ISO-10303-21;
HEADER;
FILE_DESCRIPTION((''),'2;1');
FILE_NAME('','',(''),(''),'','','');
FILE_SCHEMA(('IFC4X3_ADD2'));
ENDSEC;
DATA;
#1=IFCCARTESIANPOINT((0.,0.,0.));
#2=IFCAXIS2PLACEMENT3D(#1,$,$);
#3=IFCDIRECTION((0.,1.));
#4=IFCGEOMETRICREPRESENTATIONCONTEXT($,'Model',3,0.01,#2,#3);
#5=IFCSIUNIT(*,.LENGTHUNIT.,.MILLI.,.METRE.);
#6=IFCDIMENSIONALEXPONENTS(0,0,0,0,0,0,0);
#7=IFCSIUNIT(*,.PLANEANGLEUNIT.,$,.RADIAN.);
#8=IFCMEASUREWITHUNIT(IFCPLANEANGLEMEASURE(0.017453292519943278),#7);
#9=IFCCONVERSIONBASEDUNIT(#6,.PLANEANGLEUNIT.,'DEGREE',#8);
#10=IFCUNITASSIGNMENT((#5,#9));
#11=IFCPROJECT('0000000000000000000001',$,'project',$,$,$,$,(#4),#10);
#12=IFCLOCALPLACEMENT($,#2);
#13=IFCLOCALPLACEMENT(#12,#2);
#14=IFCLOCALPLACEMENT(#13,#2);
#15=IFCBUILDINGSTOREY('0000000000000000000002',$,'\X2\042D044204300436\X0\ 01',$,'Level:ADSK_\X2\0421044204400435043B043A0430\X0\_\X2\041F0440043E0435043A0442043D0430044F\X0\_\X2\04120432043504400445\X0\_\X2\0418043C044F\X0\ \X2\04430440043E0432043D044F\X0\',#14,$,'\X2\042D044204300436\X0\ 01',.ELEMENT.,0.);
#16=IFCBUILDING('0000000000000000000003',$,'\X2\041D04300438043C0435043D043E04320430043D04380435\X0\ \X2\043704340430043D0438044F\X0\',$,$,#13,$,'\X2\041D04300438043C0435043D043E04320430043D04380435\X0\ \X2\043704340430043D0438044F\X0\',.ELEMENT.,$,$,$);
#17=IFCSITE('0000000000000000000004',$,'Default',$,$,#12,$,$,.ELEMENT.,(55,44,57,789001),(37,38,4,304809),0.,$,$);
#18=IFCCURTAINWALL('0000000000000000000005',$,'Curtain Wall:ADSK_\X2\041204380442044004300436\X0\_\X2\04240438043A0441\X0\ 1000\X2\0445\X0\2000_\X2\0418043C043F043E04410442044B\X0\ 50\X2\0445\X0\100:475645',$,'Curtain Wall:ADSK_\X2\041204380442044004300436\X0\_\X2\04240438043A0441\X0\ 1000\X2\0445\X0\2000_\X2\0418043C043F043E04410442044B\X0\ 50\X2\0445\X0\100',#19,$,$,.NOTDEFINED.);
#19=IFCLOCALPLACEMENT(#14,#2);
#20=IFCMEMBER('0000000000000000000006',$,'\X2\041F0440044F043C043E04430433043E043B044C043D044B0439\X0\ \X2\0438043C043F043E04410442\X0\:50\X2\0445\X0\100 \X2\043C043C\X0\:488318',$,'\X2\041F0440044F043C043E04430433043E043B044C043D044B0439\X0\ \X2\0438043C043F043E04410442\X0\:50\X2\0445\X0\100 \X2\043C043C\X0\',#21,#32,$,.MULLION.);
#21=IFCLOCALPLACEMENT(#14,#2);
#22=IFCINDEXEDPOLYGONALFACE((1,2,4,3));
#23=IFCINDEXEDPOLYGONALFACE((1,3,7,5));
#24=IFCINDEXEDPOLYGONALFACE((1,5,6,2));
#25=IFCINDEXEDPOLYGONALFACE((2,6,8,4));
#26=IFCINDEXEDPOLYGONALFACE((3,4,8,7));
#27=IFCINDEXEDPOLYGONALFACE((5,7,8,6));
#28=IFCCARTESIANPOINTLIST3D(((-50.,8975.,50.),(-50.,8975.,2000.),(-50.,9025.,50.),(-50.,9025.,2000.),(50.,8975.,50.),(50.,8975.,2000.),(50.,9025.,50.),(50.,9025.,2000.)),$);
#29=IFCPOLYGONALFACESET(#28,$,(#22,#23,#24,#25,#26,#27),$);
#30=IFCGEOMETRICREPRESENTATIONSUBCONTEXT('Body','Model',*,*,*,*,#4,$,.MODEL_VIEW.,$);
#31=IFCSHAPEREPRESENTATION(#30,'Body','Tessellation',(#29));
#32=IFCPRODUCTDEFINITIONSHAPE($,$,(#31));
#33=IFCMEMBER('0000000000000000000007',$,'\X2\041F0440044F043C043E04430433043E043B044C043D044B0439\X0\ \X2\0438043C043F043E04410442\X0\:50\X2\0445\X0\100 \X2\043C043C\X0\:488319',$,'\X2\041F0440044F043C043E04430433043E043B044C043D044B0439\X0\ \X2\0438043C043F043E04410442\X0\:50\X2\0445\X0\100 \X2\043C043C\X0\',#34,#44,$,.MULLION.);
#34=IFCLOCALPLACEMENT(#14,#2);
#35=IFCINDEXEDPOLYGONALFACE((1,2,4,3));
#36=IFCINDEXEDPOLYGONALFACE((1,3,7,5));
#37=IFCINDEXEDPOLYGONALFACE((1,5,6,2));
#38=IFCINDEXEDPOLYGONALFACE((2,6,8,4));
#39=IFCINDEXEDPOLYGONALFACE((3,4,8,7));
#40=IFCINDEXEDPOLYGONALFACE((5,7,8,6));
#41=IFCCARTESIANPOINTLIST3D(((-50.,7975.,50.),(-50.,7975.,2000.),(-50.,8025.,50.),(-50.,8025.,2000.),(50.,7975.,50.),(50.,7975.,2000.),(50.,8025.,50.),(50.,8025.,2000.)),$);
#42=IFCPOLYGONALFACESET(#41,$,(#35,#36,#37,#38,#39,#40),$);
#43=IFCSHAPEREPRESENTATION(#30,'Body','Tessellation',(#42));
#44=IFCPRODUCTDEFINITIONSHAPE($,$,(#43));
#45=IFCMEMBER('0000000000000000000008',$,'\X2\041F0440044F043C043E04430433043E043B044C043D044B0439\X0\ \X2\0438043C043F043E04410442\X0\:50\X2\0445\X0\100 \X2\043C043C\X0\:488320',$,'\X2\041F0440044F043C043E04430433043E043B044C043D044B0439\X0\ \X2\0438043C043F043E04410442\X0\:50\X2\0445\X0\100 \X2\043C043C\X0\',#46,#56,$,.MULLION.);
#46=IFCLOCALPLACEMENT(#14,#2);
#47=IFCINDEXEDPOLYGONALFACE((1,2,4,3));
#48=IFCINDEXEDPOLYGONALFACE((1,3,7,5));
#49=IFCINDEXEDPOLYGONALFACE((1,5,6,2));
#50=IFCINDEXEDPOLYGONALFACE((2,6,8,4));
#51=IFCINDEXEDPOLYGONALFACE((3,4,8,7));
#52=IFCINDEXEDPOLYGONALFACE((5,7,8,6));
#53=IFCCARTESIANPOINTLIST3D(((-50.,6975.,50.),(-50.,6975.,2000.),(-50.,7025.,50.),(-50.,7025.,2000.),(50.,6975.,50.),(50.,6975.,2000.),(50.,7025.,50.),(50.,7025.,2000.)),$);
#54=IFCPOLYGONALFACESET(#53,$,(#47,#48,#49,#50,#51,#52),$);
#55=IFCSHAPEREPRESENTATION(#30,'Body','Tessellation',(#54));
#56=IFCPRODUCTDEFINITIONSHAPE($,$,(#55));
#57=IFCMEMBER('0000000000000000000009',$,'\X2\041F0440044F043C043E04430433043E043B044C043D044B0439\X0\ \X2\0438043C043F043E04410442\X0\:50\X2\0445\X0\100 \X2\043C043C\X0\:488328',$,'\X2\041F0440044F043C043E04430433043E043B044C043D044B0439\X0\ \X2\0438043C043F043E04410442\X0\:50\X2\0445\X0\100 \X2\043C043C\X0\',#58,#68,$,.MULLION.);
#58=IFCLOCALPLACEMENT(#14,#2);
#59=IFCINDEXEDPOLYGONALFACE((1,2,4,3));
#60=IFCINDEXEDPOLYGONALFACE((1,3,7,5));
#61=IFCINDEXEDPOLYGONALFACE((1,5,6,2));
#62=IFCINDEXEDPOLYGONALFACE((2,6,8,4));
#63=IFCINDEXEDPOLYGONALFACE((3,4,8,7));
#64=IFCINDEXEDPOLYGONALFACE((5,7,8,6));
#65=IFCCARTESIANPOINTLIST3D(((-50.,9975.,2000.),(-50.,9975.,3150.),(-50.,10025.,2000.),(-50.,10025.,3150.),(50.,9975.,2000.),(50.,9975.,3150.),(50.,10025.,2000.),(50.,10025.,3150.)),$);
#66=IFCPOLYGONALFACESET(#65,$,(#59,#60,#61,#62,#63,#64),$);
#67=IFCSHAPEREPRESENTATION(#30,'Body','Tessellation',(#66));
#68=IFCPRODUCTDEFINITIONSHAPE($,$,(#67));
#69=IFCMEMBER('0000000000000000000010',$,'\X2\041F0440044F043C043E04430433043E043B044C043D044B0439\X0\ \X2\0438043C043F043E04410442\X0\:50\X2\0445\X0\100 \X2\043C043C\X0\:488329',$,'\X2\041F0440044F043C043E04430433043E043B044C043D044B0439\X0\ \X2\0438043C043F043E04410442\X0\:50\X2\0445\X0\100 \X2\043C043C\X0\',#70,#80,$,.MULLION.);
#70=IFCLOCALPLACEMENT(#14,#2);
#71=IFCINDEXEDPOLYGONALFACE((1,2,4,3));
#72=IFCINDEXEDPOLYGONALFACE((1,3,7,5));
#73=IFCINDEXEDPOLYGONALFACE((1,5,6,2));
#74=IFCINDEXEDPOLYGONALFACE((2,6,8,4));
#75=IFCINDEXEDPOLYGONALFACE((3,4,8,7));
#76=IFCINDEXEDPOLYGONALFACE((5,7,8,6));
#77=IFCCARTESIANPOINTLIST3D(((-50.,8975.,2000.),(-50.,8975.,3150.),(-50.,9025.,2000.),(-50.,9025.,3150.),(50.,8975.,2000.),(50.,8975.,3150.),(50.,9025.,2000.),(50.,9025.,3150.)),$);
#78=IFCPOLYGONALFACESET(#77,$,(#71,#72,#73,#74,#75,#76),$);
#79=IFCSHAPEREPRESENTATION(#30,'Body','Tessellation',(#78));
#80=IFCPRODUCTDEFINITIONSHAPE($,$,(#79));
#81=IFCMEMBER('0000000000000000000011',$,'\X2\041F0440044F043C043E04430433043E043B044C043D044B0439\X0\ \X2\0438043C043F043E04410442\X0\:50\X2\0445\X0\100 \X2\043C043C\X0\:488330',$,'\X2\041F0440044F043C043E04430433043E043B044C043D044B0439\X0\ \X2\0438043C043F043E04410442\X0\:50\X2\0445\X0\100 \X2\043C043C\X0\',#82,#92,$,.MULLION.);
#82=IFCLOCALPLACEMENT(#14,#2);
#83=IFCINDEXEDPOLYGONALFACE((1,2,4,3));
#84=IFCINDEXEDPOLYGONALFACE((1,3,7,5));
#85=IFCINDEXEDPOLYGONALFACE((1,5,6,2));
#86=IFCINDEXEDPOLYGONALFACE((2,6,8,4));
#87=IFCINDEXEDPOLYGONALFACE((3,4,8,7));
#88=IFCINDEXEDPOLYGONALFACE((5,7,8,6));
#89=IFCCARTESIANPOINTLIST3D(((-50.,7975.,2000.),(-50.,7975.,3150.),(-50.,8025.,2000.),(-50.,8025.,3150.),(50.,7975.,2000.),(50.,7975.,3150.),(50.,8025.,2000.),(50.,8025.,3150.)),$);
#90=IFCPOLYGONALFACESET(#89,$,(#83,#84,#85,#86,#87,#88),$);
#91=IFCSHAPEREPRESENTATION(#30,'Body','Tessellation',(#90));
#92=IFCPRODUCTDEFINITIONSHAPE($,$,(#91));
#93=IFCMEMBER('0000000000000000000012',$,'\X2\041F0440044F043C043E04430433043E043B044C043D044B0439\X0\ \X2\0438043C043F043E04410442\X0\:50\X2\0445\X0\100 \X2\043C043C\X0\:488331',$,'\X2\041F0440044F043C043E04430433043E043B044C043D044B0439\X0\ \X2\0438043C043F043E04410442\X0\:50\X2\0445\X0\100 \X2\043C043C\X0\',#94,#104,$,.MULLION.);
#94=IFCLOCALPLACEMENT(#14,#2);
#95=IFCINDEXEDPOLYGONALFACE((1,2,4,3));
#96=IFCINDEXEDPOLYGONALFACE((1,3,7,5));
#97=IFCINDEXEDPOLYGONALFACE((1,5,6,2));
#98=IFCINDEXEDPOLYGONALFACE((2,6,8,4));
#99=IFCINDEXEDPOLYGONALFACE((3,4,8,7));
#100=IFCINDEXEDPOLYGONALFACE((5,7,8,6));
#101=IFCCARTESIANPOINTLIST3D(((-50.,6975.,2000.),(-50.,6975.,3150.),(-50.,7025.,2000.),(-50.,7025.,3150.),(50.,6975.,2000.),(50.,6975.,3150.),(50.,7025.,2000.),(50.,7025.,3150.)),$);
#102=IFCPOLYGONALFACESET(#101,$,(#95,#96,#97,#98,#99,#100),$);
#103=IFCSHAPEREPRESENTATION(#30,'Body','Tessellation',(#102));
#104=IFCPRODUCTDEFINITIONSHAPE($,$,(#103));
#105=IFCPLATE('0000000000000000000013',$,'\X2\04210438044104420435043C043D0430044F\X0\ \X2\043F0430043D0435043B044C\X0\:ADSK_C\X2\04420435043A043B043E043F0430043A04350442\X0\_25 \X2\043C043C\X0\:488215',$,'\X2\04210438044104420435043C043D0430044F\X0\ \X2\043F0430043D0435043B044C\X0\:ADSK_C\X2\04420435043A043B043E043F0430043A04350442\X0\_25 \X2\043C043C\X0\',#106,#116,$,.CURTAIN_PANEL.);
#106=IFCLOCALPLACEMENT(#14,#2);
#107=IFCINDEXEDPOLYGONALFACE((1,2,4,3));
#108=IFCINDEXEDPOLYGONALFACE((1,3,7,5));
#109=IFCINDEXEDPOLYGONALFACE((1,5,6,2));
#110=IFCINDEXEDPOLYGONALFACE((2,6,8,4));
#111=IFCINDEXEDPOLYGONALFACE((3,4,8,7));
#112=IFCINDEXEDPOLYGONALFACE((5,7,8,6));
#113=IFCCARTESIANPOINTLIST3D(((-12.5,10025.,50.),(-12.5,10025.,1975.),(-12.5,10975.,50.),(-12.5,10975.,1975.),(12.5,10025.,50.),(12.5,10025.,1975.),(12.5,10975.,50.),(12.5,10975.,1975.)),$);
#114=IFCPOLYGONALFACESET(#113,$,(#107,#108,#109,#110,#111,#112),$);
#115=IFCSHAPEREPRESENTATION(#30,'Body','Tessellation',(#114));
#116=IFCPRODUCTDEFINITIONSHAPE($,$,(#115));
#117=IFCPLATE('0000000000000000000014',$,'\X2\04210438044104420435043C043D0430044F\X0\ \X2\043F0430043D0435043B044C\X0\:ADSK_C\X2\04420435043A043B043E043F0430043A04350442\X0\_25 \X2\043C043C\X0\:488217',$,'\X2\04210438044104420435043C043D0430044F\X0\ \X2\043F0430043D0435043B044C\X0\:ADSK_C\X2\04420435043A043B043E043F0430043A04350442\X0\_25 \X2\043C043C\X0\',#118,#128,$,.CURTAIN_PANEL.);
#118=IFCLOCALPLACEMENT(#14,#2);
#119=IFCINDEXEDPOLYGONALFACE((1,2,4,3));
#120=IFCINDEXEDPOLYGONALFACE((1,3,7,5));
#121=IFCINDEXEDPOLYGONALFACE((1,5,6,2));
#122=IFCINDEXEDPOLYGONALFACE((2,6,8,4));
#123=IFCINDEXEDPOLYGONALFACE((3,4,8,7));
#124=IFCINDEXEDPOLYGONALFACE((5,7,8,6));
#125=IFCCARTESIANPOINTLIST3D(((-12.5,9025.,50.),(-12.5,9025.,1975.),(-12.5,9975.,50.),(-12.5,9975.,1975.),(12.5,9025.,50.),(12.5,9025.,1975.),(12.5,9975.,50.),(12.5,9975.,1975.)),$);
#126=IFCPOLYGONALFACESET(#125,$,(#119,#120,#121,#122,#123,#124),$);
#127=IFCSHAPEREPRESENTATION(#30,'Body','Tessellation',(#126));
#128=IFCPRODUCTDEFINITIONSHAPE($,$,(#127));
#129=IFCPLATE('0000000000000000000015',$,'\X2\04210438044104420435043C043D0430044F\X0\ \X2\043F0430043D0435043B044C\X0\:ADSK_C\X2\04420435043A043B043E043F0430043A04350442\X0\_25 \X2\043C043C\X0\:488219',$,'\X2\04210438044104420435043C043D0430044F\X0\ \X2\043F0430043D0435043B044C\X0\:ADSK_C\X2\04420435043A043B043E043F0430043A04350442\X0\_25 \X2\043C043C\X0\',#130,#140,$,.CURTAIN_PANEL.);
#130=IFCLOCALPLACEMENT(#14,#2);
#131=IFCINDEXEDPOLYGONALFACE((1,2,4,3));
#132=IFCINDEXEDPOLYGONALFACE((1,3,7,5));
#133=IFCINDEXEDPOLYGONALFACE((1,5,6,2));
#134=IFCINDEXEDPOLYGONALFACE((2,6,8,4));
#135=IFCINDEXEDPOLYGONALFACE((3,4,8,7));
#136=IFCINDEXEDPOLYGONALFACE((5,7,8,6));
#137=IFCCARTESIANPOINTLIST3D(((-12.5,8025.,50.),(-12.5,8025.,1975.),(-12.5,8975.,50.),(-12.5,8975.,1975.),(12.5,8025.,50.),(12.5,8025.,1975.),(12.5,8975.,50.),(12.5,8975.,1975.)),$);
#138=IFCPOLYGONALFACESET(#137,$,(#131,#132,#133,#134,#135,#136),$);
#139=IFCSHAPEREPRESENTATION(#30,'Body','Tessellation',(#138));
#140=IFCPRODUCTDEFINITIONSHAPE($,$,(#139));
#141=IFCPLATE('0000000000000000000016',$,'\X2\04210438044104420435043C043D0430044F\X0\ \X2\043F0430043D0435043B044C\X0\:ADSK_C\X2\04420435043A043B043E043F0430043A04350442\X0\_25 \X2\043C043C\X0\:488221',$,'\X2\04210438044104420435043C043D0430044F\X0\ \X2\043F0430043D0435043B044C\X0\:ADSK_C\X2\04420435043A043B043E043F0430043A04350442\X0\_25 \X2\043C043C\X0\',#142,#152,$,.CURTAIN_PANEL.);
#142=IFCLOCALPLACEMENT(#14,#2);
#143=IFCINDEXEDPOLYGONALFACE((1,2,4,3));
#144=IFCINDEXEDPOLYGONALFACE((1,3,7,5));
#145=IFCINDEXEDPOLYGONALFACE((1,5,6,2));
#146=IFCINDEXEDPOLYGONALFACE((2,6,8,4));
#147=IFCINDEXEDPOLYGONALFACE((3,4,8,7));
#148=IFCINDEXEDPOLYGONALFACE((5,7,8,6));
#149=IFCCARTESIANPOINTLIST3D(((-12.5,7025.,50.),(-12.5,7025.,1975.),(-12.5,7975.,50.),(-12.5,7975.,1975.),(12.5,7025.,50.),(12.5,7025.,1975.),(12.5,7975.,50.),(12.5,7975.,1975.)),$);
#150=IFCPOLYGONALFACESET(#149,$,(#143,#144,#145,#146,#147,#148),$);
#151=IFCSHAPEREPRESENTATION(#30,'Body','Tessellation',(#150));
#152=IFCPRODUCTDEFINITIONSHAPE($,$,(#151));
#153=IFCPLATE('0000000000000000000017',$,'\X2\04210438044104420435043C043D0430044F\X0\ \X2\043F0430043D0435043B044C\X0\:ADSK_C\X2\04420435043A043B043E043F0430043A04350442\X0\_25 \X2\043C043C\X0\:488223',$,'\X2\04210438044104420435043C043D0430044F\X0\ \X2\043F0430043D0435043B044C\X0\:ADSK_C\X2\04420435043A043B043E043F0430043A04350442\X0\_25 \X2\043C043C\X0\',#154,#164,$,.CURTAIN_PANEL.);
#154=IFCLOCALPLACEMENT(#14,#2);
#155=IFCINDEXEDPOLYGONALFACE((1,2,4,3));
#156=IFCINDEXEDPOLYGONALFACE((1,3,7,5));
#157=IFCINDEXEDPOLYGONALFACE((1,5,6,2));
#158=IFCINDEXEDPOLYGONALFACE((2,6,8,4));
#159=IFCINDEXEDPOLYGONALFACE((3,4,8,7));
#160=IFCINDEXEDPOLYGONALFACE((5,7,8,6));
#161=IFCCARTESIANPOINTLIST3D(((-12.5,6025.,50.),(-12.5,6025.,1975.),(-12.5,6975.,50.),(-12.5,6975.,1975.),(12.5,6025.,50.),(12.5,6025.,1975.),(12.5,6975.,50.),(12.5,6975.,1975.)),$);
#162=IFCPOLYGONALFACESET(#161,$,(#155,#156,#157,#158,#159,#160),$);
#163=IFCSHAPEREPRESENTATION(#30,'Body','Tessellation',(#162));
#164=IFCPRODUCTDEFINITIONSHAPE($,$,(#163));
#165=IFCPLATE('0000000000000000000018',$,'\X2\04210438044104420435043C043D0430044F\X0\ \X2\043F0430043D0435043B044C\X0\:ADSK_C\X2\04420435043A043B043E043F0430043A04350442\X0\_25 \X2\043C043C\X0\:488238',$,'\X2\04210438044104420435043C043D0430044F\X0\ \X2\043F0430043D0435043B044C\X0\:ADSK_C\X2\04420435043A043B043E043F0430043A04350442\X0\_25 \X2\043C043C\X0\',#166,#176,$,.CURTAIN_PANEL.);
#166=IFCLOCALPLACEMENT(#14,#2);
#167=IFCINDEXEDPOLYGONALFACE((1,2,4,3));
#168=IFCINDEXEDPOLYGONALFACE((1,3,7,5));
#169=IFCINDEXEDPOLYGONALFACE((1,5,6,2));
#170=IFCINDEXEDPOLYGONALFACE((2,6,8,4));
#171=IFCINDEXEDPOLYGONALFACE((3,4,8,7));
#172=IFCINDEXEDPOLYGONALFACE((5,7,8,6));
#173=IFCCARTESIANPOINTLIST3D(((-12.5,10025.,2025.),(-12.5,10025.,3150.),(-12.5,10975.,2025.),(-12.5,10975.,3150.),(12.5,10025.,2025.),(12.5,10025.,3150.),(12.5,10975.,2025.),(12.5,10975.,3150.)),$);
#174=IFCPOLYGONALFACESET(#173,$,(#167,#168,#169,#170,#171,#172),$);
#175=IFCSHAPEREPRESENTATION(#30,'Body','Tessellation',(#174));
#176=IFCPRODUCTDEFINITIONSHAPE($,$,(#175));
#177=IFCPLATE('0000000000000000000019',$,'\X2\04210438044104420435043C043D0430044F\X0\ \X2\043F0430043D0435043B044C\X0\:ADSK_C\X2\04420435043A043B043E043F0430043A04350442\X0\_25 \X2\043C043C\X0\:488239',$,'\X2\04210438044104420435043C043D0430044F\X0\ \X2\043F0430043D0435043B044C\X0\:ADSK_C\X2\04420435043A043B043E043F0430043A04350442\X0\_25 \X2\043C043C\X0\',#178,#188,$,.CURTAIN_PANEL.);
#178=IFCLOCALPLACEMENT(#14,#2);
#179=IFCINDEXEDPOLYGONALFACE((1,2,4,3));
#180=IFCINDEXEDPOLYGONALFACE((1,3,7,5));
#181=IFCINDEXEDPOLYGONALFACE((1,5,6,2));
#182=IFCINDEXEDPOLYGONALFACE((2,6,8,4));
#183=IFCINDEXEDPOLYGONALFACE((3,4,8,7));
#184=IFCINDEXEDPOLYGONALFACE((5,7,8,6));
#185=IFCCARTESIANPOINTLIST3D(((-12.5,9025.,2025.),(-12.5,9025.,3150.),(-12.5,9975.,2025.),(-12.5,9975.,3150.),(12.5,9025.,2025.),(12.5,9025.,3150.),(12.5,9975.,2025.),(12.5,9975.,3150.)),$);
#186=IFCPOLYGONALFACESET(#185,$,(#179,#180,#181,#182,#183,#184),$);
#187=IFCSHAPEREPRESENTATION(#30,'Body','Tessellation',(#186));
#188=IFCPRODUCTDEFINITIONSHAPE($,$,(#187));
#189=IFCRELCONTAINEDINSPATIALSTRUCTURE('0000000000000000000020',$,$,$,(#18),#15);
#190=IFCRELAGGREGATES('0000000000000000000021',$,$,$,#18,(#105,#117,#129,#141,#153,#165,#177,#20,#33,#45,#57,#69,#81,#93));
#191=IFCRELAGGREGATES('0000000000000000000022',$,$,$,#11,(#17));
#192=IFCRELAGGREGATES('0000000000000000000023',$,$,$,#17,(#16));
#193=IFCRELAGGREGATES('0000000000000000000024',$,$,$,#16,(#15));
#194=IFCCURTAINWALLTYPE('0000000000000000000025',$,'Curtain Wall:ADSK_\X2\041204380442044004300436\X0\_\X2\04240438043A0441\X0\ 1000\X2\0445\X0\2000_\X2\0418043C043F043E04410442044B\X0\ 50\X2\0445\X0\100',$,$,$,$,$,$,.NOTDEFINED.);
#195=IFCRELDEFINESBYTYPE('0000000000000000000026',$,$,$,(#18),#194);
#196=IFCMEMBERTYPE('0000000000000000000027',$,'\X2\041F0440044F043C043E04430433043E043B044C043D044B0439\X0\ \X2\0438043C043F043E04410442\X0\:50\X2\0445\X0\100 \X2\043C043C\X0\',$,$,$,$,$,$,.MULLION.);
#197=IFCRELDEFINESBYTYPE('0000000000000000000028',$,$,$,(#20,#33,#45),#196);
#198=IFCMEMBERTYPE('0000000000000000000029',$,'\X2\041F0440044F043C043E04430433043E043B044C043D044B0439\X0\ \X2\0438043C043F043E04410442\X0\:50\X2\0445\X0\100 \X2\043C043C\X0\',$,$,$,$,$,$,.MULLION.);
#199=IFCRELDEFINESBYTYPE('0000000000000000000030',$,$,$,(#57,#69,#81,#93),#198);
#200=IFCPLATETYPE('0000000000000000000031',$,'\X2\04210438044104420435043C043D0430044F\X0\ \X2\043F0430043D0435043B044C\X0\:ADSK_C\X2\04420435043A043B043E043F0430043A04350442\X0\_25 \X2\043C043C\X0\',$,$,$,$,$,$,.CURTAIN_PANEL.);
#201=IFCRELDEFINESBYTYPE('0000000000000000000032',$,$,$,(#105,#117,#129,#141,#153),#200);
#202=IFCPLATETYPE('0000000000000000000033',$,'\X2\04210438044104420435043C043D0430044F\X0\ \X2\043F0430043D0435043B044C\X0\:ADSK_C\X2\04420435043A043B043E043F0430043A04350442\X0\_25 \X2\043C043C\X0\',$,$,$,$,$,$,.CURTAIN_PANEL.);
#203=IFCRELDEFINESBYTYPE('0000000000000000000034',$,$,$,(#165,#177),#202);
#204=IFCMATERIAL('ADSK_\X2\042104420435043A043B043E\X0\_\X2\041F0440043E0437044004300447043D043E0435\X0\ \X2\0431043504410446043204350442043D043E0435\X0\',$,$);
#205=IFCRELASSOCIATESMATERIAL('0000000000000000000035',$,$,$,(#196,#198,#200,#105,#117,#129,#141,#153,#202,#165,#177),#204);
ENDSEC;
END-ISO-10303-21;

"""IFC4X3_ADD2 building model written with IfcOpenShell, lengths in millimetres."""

from ifc_helpers import new_model, entity, si_unit, converted_unit, direction, frame, frame_2d, origin, origin_2d_with_axis, place, context, subcontext, project, spatial, rectangle, extrude, source, transform, mapped, material, material_profile, profile_set, type_object, type_shapes, element, aggregate, save


model = new_model("IFC4X3_ADD2")

# Units and contexts
model_context = context("Model", 3, precision=0.01, world=origin(), true_north=direction((0.0, 1.0)))
body_context = subcontext(model_context, "Body", "Model", "MODEL_VIEW")
ifc_project = project(units=[si_unit("LENGTHUNIT", "METRE", prefix="MILLI"), converted_unit("PLANEANGLEUNIT", "DEGREE", entity("IfcPlaneAngleMeasure", 0.017453292519943278), si_unit("PLANEANGLEUNIT", "RADIAN"), dimensions=[0, 0, 0, 0, 0, 0, 0])], contexts=[model_context])

# Site, building, storey
site_placement = place(None, origin())
site = spatial("IfcSite", under=ifc_project, at=site_placement, Name="Default", CompositionType="ELEMENT", RefLatitude=(55, 44, 57, 789001), RefLongitude=(37, 38, 4, 304809), RefElevation=0.0)
building_placement = place(site_placement, origin())
building = spatial("IfcBuilding", under=site, at=building_placement, Name="Наименование здания", LongName="Наименование здания", CompositionType="ELEMENT")
storey_placement = place(building_placement, origin())
storey = spatial("IfcBuildingStorey", under=building, at=storey_placement, Name="Этаж 01", ObjectType="Level:ADSK_Стрелка_Проектная_Вверх_Имя уровня", LongName="Этаж 01", CompositionType="ELEMENT", Elevation=0.0)

# Curtain wall, members, plates
curtain_wall_type = type_object("IfcCurtainWallType", Name="Curtain Wall:ADSK_Витраж_Фикс 1000х2000_Импосты 50х100", PredefinedType="NOTDEFINED")
curtain_wall_placement = place(storey_placement, origin())
curtain_wall = element("IfcCurtainWall", 1, at=curtain_wall_placement, inside=storey, type_object=curtain_wall_type, Name="Curtain Wall:ADSK_Витраж_Фикс 1000х2000_Импосты 50х100:475645", ObjectType="Curtain Wall:ADSK_Витраж_Фикс 1000х2000_Импосты 50х100", PredefinedType="NOTDEFINED")
ifc_material = material(Name="ADSK_Стекло_Прозрачное бесцветное")
ifc_material_profile = material_profile(ifc_material, rectangle(XDim=50.0, YDim=100.0, at=frame_2d((0.0, 0.0), x_axis=(1.0, 0.0))), Name="50х100 мм")
ifc_profile_set = profile_set([ifc_material_profile], Name="50х100 мм")
member_type_1 = type_object("IfcMemberType", Name="Прямоугольный импост:50х100 мм", PredefinedType="MULLION", material=ifc_profile_set)
shared_shape_1 = source(origin(), body_context, "Body", "SweptSolid", [
    extrude(rectangle(XDim=50.0, YDim=100.0, at=frame_2d((0.0, 0.0), x_axis=(1.0, 0.0))), frame((0.0, 0.0, -1950.0), z_axis=(0.0, 0.0, 1.0), x_axis=(-1.0, 0.0, 0.0)), (0.0, 0.0, 1.0), 1950.0),
])
type_shapes(member_type_1, [shared_shape_1])
member_1_placement = place(curtain_wall_placement, frame((0.0, 9000.0, 50.0), z_axis=(0.0, 0.0, -1.0), x_axis=(0.0, -1.0, 0.0)))
member_1 = element("IfcMember", 2, at=member_1_placement, type_object=member_type_1, Name="Прямоугольный импост:50х100 мм:488318", ObjectType="Прямоугольный импост:50х100 мм", PredefinedType="MULLION", context=body_context, shape_type="MappedRepresentation", body=[
    mapped(shared_shape_1, transform((0.0, 0.0, 0.0), scale=1.0)),
])
member_2_placement = place(curtain_wall_placement, frame((0.0, 8000.0, 50.0), z_axis=(0.0, 0.0, -1.0), x_axis=(0.0, -1.0, 0.0)))
member_2 = element("IfcMember", 3, at=member_2_placement, type_object=member_type_1, Name="Прямоугольный импост:50х100 мм:488319", ObjectType="Прямоугольный импост:50х100 мм", PredefinedType="MULLION", context=body_context, shape_type="MappedRepresentation", body=[
    mapped(shared_shape_1, transform((0.0, 0.0, 0.0), scale=1.0)),
])
member_3_placement = place(curtain_wall_placement, frame((0.0, 7000.0, 50.0), z_axis=(0.0, 0.0, -1.0), x_axis=(0.0, -1.0, 0.0)))
member_3 = element("IfcMember", 4, at=member_3_placement, type_object=member_type_1, Name="Прямоугольный импост:50х100 мм:488320", ObjectType="Прямоугольный импост:50х100 мм", PredefinedType="MULLION", context=body_context, shape_type="MappedRepresentation", body=[
    mapped(shared_shape_1, transform((0.0, 0.0, 0.0), scale=1.0)),
])
member_type_2 = type_object("IfcMemberType", Name="Прямоугольный импост:50х100 мм", PredefinedType="MULLION", material=ifc_profile_set)
shared_shape_2 = source(origin(), body_context, "Body", "SweptSolid", [
    extrude(rectangle(XDim=50.0, YDim=100.0, at=frame_2d((0.0, 0.0), x_axis=(1.0, 0.0))), frame((0.0, 0.0, -1150.0), z_axis=(0.0, 0.0, 1.0), x_axis=(-1.0, 0.0, 0.0)), (0.0, 0.0, 1.0), 1150.0),
])
type_shapes(member_type_2, [shared_shape_2])
member_4_placement = place(curtain_wall_placement, frame((0.0, 10000.0, 2000.0), z_axis=(0.0, 0.0, -1.0), x_axis=(0.0, -1.0, 0.0)))
member_4 = element("IfcMember", 5, at=member_4_placement, type_object=member_type_2, Name="Прямоугольный импост:50х100 мм:488328", ObjectType="Прямоугольный импост:50х100 мм", PredefinedType="MULLION", context=body_context, shape_type="MappedRepresentation", body=[
    mapped(shared_shape_2, transform((0.0, 0.0, 0.0), scale=1.0)),
])
member_5_placement = place(curtain_wall_placement, frame((0.0, 9000.0, 2000.0), z_axis=(0.0, 0.0, -1.0), x_axis=(0.0, -1.0, 0.0)))
member_5 = element("IfcMember", 6, at=member_5_placement, type_object=member_type_2, Name="Прямоугольный импост:50х100 мм:488329", ObjectType="Прямоугольный импост:50х100 мм", PredefinedType="MULLION", context=body_context, shape_type="MappedRepresentation", body=[
    mapped(shared_shape_2, transform((0.0, 0.0, 0.0), scale=1.0)),
])
member_6_placement = place(curtain_wall_placement, frame((0.0, 8000.0, 2000.0), z_axis=(0.0, 0.0, -1.0), x_axis=(0.0, -1.0, 0.0)))
member_6 = element("IfcMember", 7, at=member_6_placement, type_object=member_type_2, Name="Прямоугольный импост:50х100 мм:488330", ObjectType="Прямоугольный импост:50х100 мм", PredefinedType="MULLION", context=body_context, shape_type="MappedRepresentation", body=[
    mapped(shared_shape_2, transform((0.0, 0.0, 0.0), scale=1.0)),
])
member_7_placement = place(curtain_wall_placement, frame((0.0, 7000.0, 2000.0), z_axis=(0.0, 0.0, -1.0), x_axis=(0.0, -1.0, 0.0)))
member_7 = element("IfcMember", 8, at=member_7_placement, type_object=member_type_2, Name="Прямоугольный импост:50х100 мм:488331", ObjectType="Прямоугольный импост:50х100 мм", PredefinedType="MULLION", context=body_context, shape_type="MappedRepresentation", body=[
    mapped(shared_shape_2, transform((0.0, 0.0, 0.0), scale=1.0)),
])
plate_type_1 = type_object("IfcPlateType", Name="Системная панель:ADSK_Cтеклопакет_25 мм", PredefinedType="CURTAIN_PANEL", material=ifc_material)
shared_shape_3 = source(origin(), body_context, "Body", "SweptSolid", [
    extrude(rectangle(XDim=25.0, YDim=950.0, at=origin_2d_with_axis()), frame((0.0, 0.0, 0.0), z_axis=(0.0, 0.0, 1.0), x_axis=(0.0, 1.0, 0.0)), (0.0, 0.0, 1.0), 1925.0),
])
type_shapes(plate_type_1, [shared_shape_3])
plate_1_placement = place(curtain_wall_placement, frame((0.0, 10500.0, 50.0), z_axis=(0.0, 0.0, 1.0), x_axis=(0.0, -1.0, 0.0)))
plate_1 = element("IfcPlate", 9, at=plate_1_placement, type_object=plate_type_1, material=ifc_material, Name="Системная панель:ADSK_Cтеклопакет_25 мм:488215", ObjectType="Системная панель:ADSK_Cтеклопакет_25 мм", PredefinedType="CURTAIN_PANEL", context=body_context, shape_type="MappedRepresentation", body=[
    mapped(shared_shape_3, transform((0.0, 0.0, 0.0), scale=1.0)),
])
plate_2_placement = place(curtain_wall_placement, frame((0.0, 9500.0, 50.0), z_axis=(0.0, 0.0, 1.0), x_axis=(0.0, -1.0, 0.0)))
plate_2 = element("IfcPlate", 10, at=plate_2_placement, type_object=plate_type_1, material=ifc_material, Name="Системная панель:ADSK_Cтеклопакет_25 мм:488217", ObjectType="Системная панель:ADSK_Cтеклопакет_25 мм", PredefinedType="CURTAIN_PANEL", context=body_context, shape_type="MappedRepresentation", body=[
    mapped(shared_shape_3, transform((0.0, 0.0, 0.0), scale=1.0)),
])
plate_3_placement = place(curtain_wall_placement, frame((0.0, 8500.0, 50.0), z_axis=(0.0, 0.0, 1.0), x_axis=(0.0, -1.0, 0.0)))
plate_3 = element("IfcPlate", 11, at=plate_3_placement, type_object=plate_type_1, material=ifc_material, Name="Системная панель:ADSK_Cтеклопакет_25 мм:488219", ObjectType="Системная панель:ADSK_Cтеклопакет_25 мм", PredefinedType="CURTAIN_PANEL", context=body_context, shape_type="MappedRepresentation", body=[
    mapped(shared_shape_3, transform((0.0, 0.0, 0.0), scale=1.0)),
])
plate_4_placement = place(curtain_wall_placement, frame((0.0, 7500.0, 50.0), z_axis=(0.0, 0.0, 1.0), x_axis=(0.0, -1.0, 0.0)))
plate_4 = element("IfcPlate", 12, at=plate_4_placement, type_object=plate_type_1, material=ifc_material, Name="Системная панель:ADSK_Cтеклопакет_25 мм:488221", ObjectType="Системная панель:ADSK_Cтеклопакет_25 мм", PredefinedType="CURTAIN_PANEL", context=body_context, shape_type="MappedRepresentation", body=[
    mapped(shared_shape_3, transform((0.0, 0.0, 0.0), scale=1.0)),
])
plate_5_placement = place(curtain_wall_placement, frame((0.0, 6500.0, 50.0), z_axis=(0.0, 0.0, 1.0), x_axis=(0.0, -1.0, 0.0)))
plate_5 = element("IfcPlate", 13, at=plate_5_placement, type_object=plate_type_1, material=ifc_material, Name="Системная панель:ADSK_Cтеклопакет_25 мм:488223", ObjectType="Системная панель:ADSK_Cтеклопакет_25 мм", PredefinedType="CURTAIN_PANEL", context=body_context, shape_type="MappedRepresentation", body=[
    mapped(shared_shape_3, transform((0.0, 0.0, 0.0), scale=1.0)),
])
plate_type_2 = type_object("IfcPlateType", Name="Системная панель:ADSK_Cтеклопакет_25 мм", PredefinedType="CURTAIN_PANEL", material=ifc_material)
shared_shape_4 = source(origin(), body_context, "Body", "SweptSolid", [
    extrude(rectangle(XDim=25.0, YDim=950.0, at=origin_2d_with_axis()), frame((0.0, 0.0, 0.0), z_axis=(0.0, 0.0, 1.0), x_axis=(0.0, 1.0, 0.0)), (0.0, 0.0, 1.0), 1125.0),
])
type_shapes(plate_type_2, [shared_shape_4])
plate_6_placement = place(curtain_wall_placement, frame((0.0, 10500.0, 2025.0), z_axis=(0.0, 0.0, 1.0), x_axis=(0.0, -1.0, 0.0)))
plate_6 = element("IfcPlate", 14, at=plate_6_placement, type_object=plate_type_2, material=ifc_material, Name="Системная панель:ADSK_Cтеклопакет_25 мм:488238", ObjectType="Системная панель:ADSK_Cтеклопакет_25 мм", PredefinedType="CURTAIN_PANEL", context=body_context, shape_type="MappedRepresentation", body=[
    mapped(shared_shape_4, transform((0.0, 0.0, 0.0), scale=1.0)),
])
plate_7_placement = place(curtain_wall_placement, frame((0.0, 9500.0, 2025.0), z_axis=(0.0, 0.0, 1.0), x_axis=(0.0, -1.0, 0.0)))
plate_7 = element("IfcPlate", 15, at=plate_7_placement, type_object=plate_type_2, material=ifc_material, Name="Системная панель:ADSK_Cтеклопакет_25 мм:488239", ObjectType="Системная панель:ADSK_Cтеклопакет_25 мм", PredefinedType="CURTAIN_PANEL", context=body_context, shape_type="MappedRepresentation", body=[
    mapped(shared_shape_4, transform((0.0, 0.0, 0.0), scale=1.0)),
])
aggregate(curtain_wall, [plate_1, plate_2, plate_3, plate_4, plate_5, plate_6, plate_7, member_1, member_2, member_3, member_4, member_5, member_6, member_7])

save(model, "model.ifc")
